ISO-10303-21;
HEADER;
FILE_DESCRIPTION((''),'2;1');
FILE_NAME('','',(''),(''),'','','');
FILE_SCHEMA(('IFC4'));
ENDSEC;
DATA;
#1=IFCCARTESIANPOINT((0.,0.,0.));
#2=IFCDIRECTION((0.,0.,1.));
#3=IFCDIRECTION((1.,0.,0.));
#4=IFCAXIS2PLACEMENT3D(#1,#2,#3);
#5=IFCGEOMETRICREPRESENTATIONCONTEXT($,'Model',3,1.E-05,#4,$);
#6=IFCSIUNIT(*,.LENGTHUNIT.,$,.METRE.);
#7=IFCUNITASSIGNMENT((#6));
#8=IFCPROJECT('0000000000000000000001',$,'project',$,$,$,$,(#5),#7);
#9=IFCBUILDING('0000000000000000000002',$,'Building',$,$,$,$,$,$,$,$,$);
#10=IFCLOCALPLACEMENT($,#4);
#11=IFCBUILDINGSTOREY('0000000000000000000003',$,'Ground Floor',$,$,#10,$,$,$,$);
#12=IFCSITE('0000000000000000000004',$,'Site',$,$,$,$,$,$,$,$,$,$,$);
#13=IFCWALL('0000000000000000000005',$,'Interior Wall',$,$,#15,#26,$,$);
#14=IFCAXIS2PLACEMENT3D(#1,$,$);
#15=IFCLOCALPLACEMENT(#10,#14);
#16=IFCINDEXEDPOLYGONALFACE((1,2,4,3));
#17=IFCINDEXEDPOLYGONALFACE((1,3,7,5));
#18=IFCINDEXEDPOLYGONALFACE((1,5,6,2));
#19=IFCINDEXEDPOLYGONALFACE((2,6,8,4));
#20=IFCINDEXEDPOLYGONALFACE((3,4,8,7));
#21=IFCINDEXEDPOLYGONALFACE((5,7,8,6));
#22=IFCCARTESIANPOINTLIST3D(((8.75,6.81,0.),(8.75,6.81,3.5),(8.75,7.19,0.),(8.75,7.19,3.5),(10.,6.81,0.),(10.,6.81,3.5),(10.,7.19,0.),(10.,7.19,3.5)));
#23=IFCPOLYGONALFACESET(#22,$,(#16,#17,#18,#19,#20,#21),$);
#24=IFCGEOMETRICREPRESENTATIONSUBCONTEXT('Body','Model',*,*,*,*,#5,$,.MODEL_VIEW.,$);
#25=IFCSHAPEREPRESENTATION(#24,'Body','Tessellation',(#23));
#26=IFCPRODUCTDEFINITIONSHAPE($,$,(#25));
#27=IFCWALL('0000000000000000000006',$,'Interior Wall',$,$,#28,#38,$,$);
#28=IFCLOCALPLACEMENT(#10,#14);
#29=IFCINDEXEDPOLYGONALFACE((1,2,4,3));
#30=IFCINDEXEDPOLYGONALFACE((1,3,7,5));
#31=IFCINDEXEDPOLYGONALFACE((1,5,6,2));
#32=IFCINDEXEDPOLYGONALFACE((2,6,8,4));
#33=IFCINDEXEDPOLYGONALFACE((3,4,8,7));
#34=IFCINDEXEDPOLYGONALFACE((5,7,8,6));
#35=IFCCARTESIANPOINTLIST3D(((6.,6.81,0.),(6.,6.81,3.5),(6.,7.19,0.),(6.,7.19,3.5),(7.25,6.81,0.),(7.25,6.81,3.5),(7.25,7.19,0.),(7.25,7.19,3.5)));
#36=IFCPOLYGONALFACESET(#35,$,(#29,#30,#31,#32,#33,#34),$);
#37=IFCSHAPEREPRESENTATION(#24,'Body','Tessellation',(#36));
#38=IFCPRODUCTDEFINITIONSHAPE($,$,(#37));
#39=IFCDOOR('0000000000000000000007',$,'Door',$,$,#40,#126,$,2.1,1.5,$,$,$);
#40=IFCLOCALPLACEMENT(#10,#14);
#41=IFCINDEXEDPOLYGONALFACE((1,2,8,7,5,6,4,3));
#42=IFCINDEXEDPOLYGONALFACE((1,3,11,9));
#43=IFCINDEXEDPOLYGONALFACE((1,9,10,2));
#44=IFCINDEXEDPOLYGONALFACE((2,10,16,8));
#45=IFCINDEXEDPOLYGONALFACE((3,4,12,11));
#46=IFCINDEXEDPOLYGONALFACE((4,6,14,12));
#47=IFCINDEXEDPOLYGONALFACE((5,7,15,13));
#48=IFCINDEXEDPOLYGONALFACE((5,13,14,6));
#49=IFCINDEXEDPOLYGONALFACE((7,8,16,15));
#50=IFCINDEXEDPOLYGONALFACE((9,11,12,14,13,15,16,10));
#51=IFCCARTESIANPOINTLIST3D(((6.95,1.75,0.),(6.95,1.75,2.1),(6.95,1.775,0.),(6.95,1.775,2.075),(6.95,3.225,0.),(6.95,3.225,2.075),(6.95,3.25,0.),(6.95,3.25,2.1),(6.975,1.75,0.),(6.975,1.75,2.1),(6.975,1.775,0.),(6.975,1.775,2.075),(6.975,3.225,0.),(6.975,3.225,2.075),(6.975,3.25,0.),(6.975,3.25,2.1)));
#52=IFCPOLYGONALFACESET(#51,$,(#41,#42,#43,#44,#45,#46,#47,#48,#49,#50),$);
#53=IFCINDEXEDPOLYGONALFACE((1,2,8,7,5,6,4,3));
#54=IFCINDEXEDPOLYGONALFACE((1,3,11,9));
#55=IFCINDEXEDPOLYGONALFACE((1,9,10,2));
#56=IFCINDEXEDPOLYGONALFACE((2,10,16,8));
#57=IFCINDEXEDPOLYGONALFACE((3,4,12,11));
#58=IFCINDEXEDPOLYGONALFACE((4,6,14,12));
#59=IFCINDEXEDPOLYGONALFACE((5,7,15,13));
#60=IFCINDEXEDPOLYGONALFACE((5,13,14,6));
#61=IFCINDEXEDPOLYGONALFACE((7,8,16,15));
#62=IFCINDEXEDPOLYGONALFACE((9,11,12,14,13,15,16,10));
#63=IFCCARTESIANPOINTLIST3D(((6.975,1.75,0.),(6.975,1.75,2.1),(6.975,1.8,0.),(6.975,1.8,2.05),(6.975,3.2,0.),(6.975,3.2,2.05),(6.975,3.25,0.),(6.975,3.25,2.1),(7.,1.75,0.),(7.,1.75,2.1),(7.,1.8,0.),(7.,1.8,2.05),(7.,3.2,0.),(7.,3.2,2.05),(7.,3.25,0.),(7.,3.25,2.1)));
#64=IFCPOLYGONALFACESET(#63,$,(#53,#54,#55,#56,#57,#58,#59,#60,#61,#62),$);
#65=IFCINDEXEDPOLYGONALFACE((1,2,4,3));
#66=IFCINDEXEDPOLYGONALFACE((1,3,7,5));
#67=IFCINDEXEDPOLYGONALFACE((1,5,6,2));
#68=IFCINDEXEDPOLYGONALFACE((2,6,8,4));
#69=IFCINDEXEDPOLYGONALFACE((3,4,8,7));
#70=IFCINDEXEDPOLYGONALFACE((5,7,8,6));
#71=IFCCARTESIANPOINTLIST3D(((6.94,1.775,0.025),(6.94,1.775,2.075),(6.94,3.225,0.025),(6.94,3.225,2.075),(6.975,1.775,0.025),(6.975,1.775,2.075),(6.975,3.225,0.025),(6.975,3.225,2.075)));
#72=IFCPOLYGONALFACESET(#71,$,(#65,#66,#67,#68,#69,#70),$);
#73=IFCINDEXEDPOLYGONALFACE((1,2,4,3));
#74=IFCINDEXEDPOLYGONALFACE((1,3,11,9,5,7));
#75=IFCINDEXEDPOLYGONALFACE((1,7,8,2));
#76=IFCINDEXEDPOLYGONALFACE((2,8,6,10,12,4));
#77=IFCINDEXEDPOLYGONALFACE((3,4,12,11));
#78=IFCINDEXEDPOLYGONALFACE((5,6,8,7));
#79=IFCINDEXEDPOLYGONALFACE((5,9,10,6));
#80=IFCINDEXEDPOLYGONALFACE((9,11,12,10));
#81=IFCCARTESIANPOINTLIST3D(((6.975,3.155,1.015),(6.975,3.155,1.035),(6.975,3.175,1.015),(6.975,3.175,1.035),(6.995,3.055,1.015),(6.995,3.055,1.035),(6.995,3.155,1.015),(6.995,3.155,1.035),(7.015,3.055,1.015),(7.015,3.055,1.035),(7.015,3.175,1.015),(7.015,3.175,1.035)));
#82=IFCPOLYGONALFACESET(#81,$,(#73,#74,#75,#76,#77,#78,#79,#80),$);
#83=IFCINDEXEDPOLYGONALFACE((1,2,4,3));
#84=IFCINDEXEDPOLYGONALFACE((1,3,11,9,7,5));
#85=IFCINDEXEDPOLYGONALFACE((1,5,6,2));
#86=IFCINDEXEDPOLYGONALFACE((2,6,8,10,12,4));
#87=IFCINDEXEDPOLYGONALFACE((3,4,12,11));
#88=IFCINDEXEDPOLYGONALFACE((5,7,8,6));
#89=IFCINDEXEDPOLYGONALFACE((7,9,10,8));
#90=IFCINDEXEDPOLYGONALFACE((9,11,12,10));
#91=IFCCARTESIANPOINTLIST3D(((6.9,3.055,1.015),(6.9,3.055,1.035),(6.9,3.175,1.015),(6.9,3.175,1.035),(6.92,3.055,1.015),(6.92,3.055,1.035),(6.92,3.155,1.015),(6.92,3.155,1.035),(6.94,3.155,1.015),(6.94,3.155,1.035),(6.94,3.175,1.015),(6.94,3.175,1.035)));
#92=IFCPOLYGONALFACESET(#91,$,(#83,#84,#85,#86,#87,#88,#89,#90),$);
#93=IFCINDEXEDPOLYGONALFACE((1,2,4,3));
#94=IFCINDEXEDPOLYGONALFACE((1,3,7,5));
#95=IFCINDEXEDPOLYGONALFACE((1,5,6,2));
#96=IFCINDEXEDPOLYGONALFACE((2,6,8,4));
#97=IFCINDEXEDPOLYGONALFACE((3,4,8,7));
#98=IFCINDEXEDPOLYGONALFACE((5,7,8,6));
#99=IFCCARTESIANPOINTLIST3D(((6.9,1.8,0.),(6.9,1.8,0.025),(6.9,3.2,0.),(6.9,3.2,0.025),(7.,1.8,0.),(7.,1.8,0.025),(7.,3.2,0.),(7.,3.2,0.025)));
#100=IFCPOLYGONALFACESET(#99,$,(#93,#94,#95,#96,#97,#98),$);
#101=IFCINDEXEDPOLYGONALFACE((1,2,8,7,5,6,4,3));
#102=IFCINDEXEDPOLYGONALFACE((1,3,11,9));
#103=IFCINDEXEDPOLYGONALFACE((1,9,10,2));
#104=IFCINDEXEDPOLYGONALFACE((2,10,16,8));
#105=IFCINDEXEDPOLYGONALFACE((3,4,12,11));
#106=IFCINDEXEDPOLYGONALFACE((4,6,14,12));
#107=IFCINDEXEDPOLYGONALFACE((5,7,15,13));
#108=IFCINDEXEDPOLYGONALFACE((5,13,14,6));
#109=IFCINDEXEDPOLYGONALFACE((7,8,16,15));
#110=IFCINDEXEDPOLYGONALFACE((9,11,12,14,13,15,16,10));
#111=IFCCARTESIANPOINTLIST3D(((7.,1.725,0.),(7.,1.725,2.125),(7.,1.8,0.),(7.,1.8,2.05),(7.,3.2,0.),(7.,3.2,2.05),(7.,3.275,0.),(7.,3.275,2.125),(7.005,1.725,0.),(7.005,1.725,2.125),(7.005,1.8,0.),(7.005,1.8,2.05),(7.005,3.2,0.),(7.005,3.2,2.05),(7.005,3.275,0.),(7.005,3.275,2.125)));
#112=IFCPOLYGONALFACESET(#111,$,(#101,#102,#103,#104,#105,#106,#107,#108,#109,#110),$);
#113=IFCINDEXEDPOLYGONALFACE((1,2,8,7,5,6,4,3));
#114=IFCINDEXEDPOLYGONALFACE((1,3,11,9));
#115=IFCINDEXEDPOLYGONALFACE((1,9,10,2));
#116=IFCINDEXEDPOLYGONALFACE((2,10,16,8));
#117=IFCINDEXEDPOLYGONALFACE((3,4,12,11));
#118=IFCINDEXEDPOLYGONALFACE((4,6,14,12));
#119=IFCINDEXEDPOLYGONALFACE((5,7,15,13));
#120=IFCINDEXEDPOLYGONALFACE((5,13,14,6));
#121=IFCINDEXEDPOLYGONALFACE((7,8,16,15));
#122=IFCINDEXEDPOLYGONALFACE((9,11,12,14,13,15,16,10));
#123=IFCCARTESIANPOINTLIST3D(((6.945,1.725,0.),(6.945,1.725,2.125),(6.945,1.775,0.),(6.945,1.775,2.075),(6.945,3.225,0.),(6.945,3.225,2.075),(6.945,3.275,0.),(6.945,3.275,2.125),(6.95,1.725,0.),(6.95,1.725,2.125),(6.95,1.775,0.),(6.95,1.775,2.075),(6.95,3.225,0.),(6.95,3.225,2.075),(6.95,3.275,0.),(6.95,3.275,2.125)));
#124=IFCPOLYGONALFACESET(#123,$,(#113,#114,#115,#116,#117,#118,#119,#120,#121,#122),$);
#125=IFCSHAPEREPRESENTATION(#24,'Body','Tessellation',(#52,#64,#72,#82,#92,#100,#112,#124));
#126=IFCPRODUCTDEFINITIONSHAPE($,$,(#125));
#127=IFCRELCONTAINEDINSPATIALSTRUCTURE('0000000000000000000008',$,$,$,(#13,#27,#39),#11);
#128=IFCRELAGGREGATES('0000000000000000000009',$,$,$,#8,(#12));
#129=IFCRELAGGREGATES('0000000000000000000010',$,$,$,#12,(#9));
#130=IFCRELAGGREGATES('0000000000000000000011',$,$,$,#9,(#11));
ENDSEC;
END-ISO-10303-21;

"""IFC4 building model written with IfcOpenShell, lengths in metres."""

from ifc_helpers import new_model, si_unit, frame, origin_with_axes, place, context, subcontext, project, spatial, line, indexed_curve, outline, extrude, element, save


model = new_model("IFC4")

# Units and contexts
model_context = context("Model", 3, precision=1e-05, world=origin_with_axes())
body_context = subcontext(model_context, "Body", "Model", "MODEL_VIEW")
ifc_project = project(units=[si_unit("LENGTHUNIT", "METRE")], contexts=[model_context])

# Site, building, storey
site = spatial("IfcSite", under=ifc_project, Name="Site")
building = spatial("IfcBuilding", under=site, Name="Building")
storey_placement = place(None, origin_with_axes())
storey = spatial("IfcBuildingStorey", under=building, at=storey_placement, Name="Ground Floor")

# Walls
for number, where, z_axis, x_axis, name in (
    (1, (10.0, 7.0, 0.0), (0.0, 0.0, 1.0), (-1.0, 0.0, 0.0), "Interior Wall"),
    (2, (7.25, 7.0, 0.0), (0.0, 0.0, 1.0), (-1.0, 0.0, 0.0), "Interior Wall"),
):
    element("IfcWall", number, at=place(storey_placement, frame(where, z_axis=z_axis, x_axis=x_axis)), inside=storey, Name=name, context=body_context, shape_type="SweptSolid", body=[
        extrude(outline(indexed_curve([(0.0, 0.0), (0.0, 0.38), (1.25, 0.38), (1.25, 0.0), (0.0, 0.0)], self_intersect=False)), frame((0.0, -0.19, 0.0), z_axis=(0.0, 0.0, 1.0), x_axis=(1.0, 0.0, 0.0)), (0.0, 0.0, 1.0), 3.5),
    ])

# Door
door_1_placement = place(storey_placement, frame((7.0, 1.75, 0.0), z_axis=(0.0, 0.0, 1.0), x_axis=(0.0, 1.0, 0.0)))
element("IfcDoor", 3, at=door_1_placement, inside=storey, Name="Door", OverallHeight=2.1, OverallWidth=1.5, context=body_context, shape_type="SweptSolid", body=[
    extrude(outline(indexed_curve([(0.0, 0.0), (0.0, 2.1), (1.5, 2.1), (1.5, 0.0), (1.475, 0.0), (1.475, 2.075), (0.025, 2.075), (0.025, 0.0)], segments=[line(1, 2, 3, 4, 5, 6, 7, 8, 1)])), frame((0.0, 0.025, 0.0), z_axis=(0.0, -1.0, 0.0), x_axis=(1.0, 0.0, 0.0)), (0.0, 0.0, -1.0), 0.025),
    extrude(outline(indexed_curve([(0.0, 0.0), (0.0, 2.1), (1.5, 2.1), (1.5, 0.0), (1.45, 0.0), (1.45, 2.05), (0.05, 2.05), (0.05, 0.0)], segments=[line(1, 2, 3, 4, 5, 6, 7, 8, 1)])), frame((0.0, 0.0, 0.0), z_axis=(0.0, -1.0, 0.0), x_axis=(1.0, 0.0, 0.0)), (0.0, 0.0, -1.0), 0.025),
    extrude(outline(indexed_curve([(0.0, 0.0), (1.45, 0.0), (1.45, 0.035), (0.0, 0.035)], segments=[line(1, 2, 3, 4, 1)])), frame((0.025, 0.025, 0.025), z_axis=(0.0, 0.0, 1.0), x_axis=(1.0, 0.0, 0.0)), (0.0, 0.0, 1.0), 2.05),
    extrude(outline(indexed_curve([(0.0, 0.0), (0.0, -0.04), (-0.12, -0.04), (-0.12, -0.02), (-0.02, -0.02), (-0.02, 0.0)], segments=[line(1, 2, 3, 4, 5, 6, 1)])), frame((1.425, 0.025, 1.015), z_axis=(0.0, 0.0, 1.0), x_axis=(1.0, 0.0, 0.0)), (0.0, 0.0, 1.0), 0.02),
    extrude(outline(indexed_curve([(0.0, 0.0), (0.0, 0.04), (-0.12, 0.04), (-0.12, 0.02), (-0.02, 0.02), (-0.02, 0.0)], segments=[line(1, 2, 3, 4, 5, 6, 1)])), frame((1.425, 0.06, 1.015), z_axis=(0.0, 0.0, 1.0), x_axis=(1.0, 0.0, 0.0)), (0.0, 0.0, 1.0), 0.02),
    extrude(outline(indexed_curve([(0.0, 0.0), (1.4, 0.0), (1.4, 0.1), (0.0, 0.1)], segments=[line(1, 2, 3, 4, 1)])), frame((0.05, 0.0, 0.0), z_axis=(0.0, 0.0, 1.0), x_axis=(1.0, 0.0, 0.0)), (0.0, 0.0, 1.0), 0.025),
    extrude(outline(indexed_curve([(0.0, 0.0), (0.0, 2.125), (1.55, 2.125), (1.55, 0.0), (1.475, 0.0), (1.475, 2.05), (0.075, 2.05), (0.075, 0.0)], segments=[line(1, 2, 3, 4, 5, 6, 7, 8, 1)])), frame((-0.025, -0.005, 0.0), z_axis=(0.0, -1.0, 0.0), x_axis=(1.0, 0.0, 0.0)), (0.0, 0.0, -1.0), 0.005),
    extrude(outline(indexed_curve([(0.0, 0.0), (0.0, 2.125), (1.55, 2.125), (1.55, 0.0), (1.5, 0.0), (1.5, 2.075), (0.05, 2.075), (0.05, 0.0)], segments=[line(1, 2, 3, 4, 5, 6, 7, 8, 1)])), frame((-0.025, 0.05, 0.0), z_axis=(0.0, -1.0, 0.0), x_axis=(1.0, 0.0, 0.0)), (0.0, 0.0, -1.0), 0.005),
])

save(model, "model.ifc")
